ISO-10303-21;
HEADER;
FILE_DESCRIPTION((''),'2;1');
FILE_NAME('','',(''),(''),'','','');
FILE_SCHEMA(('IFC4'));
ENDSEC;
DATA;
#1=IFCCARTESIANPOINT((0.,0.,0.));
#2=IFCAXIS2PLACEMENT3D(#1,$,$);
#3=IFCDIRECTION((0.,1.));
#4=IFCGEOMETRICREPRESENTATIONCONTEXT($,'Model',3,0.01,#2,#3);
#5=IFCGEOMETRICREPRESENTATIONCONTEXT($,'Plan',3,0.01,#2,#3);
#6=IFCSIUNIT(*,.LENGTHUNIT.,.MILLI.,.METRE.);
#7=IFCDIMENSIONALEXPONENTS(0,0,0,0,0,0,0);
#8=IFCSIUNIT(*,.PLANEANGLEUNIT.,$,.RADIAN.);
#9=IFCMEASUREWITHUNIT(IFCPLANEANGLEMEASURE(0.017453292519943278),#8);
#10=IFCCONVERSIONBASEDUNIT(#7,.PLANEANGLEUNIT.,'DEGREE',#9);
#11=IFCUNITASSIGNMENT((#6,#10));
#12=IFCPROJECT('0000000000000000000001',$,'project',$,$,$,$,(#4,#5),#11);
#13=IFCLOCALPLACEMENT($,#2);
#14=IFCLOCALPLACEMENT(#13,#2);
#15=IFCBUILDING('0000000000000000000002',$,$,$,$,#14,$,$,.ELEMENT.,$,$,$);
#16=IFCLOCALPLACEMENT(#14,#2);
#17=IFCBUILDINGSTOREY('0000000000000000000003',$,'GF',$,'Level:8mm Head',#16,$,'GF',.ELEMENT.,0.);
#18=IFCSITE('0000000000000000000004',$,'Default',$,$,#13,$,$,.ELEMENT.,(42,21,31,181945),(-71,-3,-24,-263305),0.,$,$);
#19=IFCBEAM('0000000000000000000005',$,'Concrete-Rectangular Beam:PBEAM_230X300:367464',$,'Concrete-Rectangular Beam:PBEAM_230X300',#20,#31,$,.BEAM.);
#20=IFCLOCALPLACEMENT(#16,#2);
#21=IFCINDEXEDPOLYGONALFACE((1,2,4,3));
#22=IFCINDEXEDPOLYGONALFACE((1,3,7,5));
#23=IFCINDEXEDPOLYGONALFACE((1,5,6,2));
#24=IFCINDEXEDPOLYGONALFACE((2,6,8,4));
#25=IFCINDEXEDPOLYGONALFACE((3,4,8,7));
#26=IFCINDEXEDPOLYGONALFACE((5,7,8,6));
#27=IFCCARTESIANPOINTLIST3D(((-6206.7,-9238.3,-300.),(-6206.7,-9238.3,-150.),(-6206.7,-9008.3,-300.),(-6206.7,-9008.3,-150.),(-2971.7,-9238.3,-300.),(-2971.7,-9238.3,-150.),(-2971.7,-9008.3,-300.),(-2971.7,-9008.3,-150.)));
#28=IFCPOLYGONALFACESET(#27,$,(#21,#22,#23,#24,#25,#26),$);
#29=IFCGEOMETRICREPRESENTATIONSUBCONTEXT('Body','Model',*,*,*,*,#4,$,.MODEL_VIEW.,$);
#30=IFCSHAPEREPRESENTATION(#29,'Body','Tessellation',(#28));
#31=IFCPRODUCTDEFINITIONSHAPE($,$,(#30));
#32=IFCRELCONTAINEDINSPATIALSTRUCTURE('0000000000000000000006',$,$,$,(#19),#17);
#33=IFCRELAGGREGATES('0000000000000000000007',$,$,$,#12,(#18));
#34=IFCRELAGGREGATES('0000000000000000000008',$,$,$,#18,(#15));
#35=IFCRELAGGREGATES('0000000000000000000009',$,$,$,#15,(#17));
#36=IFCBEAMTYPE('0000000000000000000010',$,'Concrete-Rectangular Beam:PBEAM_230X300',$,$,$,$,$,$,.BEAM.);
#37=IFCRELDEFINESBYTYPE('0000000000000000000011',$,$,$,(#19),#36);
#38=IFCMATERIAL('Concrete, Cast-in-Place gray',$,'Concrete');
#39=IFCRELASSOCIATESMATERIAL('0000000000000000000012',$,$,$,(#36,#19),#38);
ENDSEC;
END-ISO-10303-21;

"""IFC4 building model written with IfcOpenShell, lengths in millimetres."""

from ifc_helpers import new_model, entity, si_unit, converted_unit, direction, frame, origin, place, context, subcontext, project, spatial, indexed_curve, outline, extrude, source, transform, mapped, material, type_object, type_shapes, element, save


model = new_model("IFC4")

# Units and contexts
model_context = context("Model", 3, precision=0.01, world=origin(), true_north=direction((0.0, 1.0)))
plan_context = context("Plan", 3, precision=0.01, world=origin(), true_north=direction((0.0, 1.0)))
body_context = subcontext(model_context, "Body", "Model", "MODEL_VIEW")
ifc_project = project(units=[si_unit("LENGTHUNIT", "METRE", prefix="MILLI"), converted_unit("PLANEANGLEUNIT", "DEGREE", entity("IfcPlaneAngleMeasure", 0.017453292519943278), si_unit("PLANEANGLEUNIT", "RADIAN"), dimensions=[0, 0, 0, 0, 0, 0, 0])], contexts=[model_context, plan_context])

# Site, building, storey
site_placement = place(None, origin())
site = spatial("IfcSite", under=ifc_project, at=site_placement, Name="Default", CompositionType="ELEMENT", RefLatitude=(42, 21, 31, 181945), RefLongitude=(-71, -3, -24, -263305), RefElevation=0.0)
building_placement = place(site_placement, origin())
building = spatial("IfcBuilding", under=site, at=building_placement, CompositionType="ELEMENT")
storey_placement = place(building_placement, origin())
storey = spatial("IfcBuildingStorey", under=building, at=storey_placement, Name="GF", ObjectType="Level:8mm Head", LongName="GF", CompositionType="ELEMENT", Elevation=0.0)

# Shared definitions
ifc_material = material(Name="Concrete, Cast-in-Place gray", Category="Concrete")

# Beam
beam_type_1 = type_object("IfcBeamType", Name="Concrete-Rectangular Beam:PBEAM_230X300", PredefinedType="BEAM", material=ifc_material)
shared_shape_1 = source(origin(), body_context, "Body", "SweptSolid", [
    extrude(outline(indexed_curve([(-75.0, -115.0), (75.0, -115.0), (75.0, 115.0), (-75.0, 115.0), (-75.0, -115.0)], self_intersect=False)), frame((-6206.7, -9123.3, -225.0), z_axis=(1.0, 0.0, 0.0), x_axis=(0.0, 0.0, -1.0)), (0.0, 0.0, 1.0), 3235.0),
])
type_shapes(beam_type_1, [shared_shape_1])
beam_1_placement = place(storey_placement, origin())
element("IfcBeam", 1, at=beam_1_placement, inside=storey, type_object=beam_type_1, material=ifc_material, Name="Concrete-Rectangular Beam:PBEAM_230X300:367464", ObjectType="Concrete-Rectangular Beam:PBEAM_230X300", PredefinedType="BEAM", context=body_context, shape_type="MappedRepresentation", body=[
    mapped(shared_shape_1, transform((0.0, 0.0, 0.0), scale=1.0)),
])

save(model, "model.ifc")
